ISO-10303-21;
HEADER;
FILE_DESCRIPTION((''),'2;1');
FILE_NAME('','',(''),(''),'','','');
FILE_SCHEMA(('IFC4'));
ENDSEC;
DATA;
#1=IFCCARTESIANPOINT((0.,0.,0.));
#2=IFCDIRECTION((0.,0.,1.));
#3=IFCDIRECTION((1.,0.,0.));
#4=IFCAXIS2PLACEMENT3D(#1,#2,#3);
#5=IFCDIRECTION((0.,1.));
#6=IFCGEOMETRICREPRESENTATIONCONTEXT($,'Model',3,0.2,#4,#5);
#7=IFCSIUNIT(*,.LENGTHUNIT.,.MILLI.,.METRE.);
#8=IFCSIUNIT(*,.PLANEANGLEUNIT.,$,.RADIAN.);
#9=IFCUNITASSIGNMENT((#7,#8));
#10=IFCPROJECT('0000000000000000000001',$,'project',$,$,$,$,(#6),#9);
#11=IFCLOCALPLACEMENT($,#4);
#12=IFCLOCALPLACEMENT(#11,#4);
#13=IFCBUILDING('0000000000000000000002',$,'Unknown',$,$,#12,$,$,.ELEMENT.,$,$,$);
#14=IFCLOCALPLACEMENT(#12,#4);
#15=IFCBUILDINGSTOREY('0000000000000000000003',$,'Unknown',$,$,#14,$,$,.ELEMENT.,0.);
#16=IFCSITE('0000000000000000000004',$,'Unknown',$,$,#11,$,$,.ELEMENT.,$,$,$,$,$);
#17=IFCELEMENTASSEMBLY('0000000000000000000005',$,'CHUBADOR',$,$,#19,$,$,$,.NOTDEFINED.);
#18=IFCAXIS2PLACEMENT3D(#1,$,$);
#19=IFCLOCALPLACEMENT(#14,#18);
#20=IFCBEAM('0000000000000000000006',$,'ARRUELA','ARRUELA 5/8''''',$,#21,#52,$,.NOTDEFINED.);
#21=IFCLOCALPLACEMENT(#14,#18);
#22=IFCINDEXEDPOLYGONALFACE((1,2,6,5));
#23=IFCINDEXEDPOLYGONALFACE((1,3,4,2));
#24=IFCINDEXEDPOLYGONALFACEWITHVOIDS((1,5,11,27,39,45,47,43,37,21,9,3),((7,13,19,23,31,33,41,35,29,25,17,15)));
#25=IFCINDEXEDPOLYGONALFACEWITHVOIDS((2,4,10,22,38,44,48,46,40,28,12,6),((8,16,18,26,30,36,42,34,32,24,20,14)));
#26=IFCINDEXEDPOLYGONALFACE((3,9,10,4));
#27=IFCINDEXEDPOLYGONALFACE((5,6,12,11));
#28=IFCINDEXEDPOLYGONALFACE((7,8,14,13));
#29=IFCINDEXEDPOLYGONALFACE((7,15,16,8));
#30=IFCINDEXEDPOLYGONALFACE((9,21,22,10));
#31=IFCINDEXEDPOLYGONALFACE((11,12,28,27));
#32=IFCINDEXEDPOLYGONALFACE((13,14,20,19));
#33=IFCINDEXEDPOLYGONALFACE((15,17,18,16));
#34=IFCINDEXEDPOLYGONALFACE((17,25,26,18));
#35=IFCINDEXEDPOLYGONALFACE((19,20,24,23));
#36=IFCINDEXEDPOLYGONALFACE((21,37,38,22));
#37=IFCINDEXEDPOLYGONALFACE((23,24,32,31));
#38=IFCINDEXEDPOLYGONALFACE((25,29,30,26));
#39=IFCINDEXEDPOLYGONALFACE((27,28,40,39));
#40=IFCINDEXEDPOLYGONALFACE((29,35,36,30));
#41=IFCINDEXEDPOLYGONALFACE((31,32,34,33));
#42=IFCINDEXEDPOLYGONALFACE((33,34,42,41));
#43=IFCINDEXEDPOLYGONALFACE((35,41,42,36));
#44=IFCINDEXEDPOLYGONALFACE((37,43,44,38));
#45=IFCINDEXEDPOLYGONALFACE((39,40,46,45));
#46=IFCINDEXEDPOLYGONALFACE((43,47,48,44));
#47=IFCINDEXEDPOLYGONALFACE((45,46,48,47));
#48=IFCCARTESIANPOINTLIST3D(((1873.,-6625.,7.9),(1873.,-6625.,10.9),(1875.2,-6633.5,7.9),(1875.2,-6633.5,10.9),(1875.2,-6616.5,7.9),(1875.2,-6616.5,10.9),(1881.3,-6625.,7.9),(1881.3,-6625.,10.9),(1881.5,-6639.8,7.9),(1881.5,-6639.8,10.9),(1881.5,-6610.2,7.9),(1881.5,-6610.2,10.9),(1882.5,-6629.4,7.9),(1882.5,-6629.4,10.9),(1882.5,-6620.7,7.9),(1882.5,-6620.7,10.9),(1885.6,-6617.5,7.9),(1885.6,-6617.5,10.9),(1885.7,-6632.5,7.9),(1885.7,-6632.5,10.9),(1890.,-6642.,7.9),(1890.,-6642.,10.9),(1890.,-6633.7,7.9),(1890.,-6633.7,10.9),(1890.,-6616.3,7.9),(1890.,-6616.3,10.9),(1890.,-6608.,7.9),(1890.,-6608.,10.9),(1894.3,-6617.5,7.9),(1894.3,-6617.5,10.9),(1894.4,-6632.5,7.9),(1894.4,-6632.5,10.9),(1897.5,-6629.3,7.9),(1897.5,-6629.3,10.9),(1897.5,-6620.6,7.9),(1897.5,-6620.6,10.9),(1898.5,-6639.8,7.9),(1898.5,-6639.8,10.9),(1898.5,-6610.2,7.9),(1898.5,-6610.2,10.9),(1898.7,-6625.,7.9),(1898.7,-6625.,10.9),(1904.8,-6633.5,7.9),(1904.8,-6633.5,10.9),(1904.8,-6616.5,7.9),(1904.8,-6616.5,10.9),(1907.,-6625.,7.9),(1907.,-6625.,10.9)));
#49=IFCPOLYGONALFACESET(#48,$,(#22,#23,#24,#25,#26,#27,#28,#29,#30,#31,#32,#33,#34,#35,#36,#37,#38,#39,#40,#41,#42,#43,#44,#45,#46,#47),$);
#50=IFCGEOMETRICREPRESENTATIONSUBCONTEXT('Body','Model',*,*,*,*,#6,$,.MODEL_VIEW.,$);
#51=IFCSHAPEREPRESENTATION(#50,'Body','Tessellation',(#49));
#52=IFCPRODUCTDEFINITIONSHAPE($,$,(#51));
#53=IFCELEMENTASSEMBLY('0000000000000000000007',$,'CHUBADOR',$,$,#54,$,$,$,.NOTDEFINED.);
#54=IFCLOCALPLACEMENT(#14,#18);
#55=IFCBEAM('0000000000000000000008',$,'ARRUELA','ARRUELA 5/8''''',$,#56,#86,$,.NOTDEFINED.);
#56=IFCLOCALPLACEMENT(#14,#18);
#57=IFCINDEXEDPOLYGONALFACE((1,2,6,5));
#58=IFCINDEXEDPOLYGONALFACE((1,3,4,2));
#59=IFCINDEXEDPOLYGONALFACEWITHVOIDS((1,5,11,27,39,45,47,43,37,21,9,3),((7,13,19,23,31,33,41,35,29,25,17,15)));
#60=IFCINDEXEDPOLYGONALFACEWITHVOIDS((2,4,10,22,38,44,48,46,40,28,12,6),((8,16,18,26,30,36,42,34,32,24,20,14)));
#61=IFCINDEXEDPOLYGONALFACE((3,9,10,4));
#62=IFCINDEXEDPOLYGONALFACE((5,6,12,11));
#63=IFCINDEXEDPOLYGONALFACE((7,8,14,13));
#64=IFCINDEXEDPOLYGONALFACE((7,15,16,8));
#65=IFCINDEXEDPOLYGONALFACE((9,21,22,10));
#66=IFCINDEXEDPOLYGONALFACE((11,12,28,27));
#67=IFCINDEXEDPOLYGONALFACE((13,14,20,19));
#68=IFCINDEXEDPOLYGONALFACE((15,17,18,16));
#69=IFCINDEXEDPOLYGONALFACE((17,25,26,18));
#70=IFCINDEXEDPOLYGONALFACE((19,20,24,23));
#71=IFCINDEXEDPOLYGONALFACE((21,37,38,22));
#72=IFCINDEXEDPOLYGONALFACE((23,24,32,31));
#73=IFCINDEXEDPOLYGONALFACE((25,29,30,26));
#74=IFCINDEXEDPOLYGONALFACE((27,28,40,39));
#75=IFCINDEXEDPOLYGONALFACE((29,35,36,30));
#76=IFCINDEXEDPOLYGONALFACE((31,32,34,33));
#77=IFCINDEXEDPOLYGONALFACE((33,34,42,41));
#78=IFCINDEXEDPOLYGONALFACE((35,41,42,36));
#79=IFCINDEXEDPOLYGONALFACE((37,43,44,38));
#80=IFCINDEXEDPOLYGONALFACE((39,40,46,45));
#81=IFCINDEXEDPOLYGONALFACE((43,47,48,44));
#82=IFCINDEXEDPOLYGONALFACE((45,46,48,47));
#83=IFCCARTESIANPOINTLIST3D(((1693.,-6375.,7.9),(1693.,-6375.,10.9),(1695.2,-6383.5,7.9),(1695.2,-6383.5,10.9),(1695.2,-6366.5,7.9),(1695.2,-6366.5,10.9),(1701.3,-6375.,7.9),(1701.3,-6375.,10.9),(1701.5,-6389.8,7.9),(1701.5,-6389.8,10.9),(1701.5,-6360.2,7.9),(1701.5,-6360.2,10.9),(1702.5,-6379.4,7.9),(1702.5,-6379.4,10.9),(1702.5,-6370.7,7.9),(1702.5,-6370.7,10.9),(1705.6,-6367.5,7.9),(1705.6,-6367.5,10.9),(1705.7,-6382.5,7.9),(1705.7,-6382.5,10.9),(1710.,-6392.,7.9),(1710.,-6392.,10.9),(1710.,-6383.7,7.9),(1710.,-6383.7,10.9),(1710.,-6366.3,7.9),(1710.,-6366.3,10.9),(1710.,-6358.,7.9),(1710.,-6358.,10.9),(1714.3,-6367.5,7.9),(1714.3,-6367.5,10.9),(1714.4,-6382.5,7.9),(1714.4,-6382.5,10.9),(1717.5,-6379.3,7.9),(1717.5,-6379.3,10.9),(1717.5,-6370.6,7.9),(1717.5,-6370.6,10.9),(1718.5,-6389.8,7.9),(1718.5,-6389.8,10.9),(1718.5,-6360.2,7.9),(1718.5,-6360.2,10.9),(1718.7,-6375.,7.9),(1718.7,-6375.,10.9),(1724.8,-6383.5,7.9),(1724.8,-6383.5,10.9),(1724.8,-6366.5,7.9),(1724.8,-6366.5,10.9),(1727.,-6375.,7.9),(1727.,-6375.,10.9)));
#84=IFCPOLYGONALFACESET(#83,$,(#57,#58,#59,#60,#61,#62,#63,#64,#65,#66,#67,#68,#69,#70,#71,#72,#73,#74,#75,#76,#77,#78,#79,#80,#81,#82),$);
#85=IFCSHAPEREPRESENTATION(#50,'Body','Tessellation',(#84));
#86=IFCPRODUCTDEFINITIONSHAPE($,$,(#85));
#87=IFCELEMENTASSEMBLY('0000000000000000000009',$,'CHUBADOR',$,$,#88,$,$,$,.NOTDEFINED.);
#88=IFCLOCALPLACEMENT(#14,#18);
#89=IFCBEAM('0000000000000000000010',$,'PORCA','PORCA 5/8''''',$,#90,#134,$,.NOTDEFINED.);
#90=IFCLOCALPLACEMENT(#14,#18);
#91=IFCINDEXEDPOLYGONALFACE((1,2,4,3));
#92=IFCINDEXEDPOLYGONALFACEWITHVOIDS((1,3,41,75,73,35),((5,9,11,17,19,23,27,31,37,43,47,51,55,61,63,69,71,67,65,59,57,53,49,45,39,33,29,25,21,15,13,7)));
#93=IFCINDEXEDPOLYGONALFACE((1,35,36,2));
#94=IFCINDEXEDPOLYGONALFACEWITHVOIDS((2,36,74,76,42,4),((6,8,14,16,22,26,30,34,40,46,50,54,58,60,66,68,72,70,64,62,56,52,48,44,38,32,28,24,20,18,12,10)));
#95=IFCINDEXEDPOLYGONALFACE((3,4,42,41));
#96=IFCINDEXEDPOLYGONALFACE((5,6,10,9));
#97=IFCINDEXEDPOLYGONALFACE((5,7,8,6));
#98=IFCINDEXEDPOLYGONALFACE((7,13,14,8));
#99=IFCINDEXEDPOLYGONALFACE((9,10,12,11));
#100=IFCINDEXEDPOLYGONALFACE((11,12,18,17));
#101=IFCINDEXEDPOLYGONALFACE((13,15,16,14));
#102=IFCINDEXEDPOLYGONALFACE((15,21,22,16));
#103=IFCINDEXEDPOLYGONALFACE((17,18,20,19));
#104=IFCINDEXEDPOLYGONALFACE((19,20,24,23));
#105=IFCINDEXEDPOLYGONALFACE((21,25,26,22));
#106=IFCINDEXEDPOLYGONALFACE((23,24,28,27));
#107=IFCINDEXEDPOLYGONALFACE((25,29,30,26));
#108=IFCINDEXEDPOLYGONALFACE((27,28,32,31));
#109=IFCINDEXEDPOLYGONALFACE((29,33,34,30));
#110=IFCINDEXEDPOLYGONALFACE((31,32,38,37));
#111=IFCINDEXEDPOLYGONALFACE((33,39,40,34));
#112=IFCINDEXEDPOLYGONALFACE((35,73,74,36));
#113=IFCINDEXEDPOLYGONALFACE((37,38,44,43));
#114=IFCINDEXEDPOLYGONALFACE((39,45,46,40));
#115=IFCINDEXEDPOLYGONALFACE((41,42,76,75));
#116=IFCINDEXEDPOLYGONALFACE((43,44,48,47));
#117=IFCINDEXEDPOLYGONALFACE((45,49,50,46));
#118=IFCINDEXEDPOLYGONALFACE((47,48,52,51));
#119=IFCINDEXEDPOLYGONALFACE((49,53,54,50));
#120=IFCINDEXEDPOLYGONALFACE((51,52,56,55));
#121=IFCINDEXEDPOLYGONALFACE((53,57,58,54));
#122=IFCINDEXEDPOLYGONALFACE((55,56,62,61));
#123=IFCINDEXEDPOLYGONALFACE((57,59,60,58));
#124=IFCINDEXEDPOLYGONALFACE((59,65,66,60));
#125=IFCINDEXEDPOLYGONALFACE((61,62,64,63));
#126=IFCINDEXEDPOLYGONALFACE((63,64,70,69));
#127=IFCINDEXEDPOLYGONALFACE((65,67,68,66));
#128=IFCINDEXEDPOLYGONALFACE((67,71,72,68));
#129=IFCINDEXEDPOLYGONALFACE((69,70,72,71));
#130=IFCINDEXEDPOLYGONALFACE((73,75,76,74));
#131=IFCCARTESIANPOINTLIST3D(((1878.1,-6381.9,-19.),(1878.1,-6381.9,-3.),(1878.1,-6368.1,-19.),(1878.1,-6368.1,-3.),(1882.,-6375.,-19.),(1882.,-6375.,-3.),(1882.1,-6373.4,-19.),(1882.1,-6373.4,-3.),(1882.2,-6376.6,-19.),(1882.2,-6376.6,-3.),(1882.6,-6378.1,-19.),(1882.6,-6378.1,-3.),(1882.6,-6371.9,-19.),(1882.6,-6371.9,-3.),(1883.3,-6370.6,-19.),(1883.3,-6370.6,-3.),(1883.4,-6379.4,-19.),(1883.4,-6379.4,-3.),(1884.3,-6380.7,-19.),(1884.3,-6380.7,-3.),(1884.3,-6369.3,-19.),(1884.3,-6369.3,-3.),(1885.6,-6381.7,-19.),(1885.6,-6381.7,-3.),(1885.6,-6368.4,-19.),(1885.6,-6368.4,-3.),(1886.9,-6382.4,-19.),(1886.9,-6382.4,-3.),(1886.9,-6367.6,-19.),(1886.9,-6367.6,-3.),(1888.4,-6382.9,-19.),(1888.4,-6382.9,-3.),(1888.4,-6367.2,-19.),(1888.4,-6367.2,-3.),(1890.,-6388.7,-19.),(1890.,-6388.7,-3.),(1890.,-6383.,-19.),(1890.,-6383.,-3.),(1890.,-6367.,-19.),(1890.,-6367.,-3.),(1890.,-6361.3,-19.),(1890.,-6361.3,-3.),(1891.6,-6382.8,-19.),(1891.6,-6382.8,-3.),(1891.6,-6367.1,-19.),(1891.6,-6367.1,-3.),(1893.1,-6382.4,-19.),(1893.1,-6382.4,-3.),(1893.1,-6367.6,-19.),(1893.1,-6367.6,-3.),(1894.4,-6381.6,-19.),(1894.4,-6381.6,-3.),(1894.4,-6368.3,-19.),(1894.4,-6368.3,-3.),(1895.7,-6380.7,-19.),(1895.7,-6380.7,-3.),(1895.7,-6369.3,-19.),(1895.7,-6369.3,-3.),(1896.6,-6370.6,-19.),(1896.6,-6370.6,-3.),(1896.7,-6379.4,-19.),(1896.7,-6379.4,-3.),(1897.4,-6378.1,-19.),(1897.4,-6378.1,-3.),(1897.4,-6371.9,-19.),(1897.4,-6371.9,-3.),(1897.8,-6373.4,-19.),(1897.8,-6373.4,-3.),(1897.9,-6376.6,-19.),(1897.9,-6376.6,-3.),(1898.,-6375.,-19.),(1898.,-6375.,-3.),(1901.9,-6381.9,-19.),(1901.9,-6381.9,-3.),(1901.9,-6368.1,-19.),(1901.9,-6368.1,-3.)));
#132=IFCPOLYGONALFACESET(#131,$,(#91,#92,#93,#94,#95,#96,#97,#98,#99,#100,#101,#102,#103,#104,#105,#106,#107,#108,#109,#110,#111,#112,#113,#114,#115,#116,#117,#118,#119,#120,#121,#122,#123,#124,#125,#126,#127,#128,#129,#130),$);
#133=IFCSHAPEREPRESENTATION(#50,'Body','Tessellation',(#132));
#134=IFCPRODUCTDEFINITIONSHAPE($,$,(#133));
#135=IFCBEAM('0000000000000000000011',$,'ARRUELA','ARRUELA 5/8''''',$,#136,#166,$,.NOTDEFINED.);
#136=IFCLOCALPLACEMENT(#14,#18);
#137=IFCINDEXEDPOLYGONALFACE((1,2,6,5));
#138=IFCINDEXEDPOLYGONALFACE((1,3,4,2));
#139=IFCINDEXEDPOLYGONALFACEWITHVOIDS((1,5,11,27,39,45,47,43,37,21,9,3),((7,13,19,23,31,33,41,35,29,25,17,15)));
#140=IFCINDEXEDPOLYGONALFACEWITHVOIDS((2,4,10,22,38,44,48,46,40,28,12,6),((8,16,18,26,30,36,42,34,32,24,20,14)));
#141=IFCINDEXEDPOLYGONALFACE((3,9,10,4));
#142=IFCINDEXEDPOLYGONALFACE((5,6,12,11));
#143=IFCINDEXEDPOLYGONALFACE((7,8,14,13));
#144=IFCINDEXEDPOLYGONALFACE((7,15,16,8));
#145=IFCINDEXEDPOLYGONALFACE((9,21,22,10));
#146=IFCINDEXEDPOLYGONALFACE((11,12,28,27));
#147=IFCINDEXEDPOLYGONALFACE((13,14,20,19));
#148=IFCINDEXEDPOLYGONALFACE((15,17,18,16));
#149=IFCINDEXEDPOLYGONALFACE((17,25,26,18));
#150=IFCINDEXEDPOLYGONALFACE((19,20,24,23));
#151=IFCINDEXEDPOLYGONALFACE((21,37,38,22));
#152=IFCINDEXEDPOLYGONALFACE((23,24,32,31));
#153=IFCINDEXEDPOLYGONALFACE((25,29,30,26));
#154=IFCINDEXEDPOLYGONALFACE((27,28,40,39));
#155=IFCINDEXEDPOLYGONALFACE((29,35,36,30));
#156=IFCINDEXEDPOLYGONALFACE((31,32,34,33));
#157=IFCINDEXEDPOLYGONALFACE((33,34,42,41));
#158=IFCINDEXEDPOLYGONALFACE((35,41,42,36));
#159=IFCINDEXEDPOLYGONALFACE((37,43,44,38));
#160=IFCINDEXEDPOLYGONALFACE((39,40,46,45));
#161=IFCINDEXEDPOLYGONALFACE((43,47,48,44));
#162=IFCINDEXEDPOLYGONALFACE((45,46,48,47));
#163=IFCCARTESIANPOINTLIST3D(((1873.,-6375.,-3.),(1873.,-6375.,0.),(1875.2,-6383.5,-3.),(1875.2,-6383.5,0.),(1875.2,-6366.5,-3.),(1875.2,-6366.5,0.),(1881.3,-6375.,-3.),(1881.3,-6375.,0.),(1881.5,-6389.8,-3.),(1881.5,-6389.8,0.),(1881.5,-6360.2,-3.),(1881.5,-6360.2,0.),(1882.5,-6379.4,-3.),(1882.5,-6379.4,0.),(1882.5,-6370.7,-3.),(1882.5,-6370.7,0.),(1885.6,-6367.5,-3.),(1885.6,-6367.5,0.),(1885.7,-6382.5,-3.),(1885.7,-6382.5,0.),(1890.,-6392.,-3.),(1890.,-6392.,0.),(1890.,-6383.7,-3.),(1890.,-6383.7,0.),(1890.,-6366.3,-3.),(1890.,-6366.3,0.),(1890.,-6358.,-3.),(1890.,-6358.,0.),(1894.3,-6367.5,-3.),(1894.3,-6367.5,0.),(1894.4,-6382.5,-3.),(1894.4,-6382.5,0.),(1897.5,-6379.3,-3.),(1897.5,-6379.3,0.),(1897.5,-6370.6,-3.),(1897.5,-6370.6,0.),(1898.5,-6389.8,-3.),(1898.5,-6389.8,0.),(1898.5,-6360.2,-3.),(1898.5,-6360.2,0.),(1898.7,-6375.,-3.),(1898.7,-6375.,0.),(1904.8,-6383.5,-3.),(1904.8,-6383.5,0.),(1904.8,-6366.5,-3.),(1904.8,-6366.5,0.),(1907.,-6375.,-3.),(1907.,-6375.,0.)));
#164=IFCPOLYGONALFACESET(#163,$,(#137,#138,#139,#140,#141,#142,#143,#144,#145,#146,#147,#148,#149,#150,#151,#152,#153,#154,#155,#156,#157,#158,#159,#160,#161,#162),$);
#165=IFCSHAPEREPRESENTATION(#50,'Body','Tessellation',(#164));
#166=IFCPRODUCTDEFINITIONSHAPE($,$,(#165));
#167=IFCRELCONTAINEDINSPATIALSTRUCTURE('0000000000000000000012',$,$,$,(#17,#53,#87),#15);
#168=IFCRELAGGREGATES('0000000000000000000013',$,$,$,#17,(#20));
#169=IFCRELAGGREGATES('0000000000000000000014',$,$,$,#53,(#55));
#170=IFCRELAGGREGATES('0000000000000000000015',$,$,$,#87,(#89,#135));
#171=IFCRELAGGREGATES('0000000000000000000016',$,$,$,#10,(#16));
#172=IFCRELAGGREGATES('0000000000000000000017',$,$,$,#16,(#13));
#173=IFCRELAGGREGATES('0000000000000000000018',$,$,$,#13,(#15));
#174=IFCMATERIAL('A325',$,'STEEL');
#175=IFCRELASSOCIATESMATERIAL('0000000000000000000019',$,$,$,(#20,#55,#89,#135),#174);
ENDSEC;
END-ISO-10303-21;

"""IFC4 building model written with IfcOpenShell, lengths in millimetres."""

from ifc_helpers import new_model, si_unit, direction, frame, origin_with_axes, place, context, subcontext, project, spatial, line, indexed_curve, outline, extrude, material, element, aggregate, save


model = new_model("IFC4")

# Units and contexts
model_context = context("Model", 3, precision=0.2, world=origin_with_axes(), true_north=direction((0.0, 1.0)))
body_context = subcontext(model_context, "Body", "Model", "MODEL_VIEW")
ifc_project = project(units=[si_unit("LENGTHUNIT", "METRE", prefix="MILLI"), si_unit("PLANEANGLEUNIT", "RADIAN")], contexts=[model_context])

# Site, building, storey
site_placement = place(None, origin_with_axes())
site = spatial("IfcSite", under=ifc_project, at=site_placement, Name="Unknown", CompositionType="ELEMENT")
building_placement = place(site_placement, origin_with_axes())
building = spatial("IfcBuilding", under=site, at=building_placement, Name="Unknown", CompositionType="ELEMENT")
storey_placement = place(building_placement, origin_with_axes())
storey = spatial("IfcBuildingStorey", under=building, at=storey_placement, Name="Unknown", CompositionType="ELEMENT", Elevation=0.0)

# Shared definitions
ifc_material_1 = material(Name="A325", Category="STEEL")

# Element assembly, beam
assembly_1_placement = place(storey_placement, frame((1890.0, -6625.0, -52.1), z_axis=(1.0, 0.0, 0.0), x_axis=(0.0, 0.0, -1.0)))
assembly_1 = element("IfcElementAssembly", 1, at=assembly_1_placement, inside=storey, Name="CHUBADOR", PredefinedType="NOTDEFINED")
beam_1_placement = place(assembly_1_placement, frame((-63.0, 0.0, 0.0), z_axis=(0.0, 0.0, 1.0), x_axis=(1.0, 0.0, 0.0)))
beam_1 = element("IfcBeam", 2, at=beam_1_placement, material=ifc_material_1, Name="ARRUELA", Description="ARRUELA 5/8''", PredefinedType="NOTDEFINED", context=body_context, shape_type="SolidModel", body=[
    extrude(outline(indexed_curve([(17.0, 0.0), (14.8, 8.5), (8.5, 14.8), (0.0, 17.0), (-8.5, 14.8), (-14.8, 8.5), (-17.0, 0.0), (-14.8, -8.5), (-8.5, -14.8), (0.0, -17.0), (8.5, -14.8), (14.8, -8.5)], segments=[line(1, 2, 3, 4, 5, 6, 7, 8, 9, 10, 11, 12, 1)]), holes=[indexed_curve([(8.7, 0.0), (7.5, -4.3), (4.3, -7.5), (0.0, -8.7), (-4.3, -7.5), (-7.5, -4.3), (-8.7, 0.0), (-7.5, 4.3), (-4.3, 7.5), (0.0, 8.7), (4.3, 7.5), (7.5, 4.3)], segments=[line(1, 2, 3, 4, 5, 6, 7, 8, 9, 10, 11, 12, 1)])]), frame((0.0, 0.0, 0.0), z_axis=(-1.0, 0.0, 0.0), x_axis=(0.0, 0.0, 1.0)), (0.0, 0.0, -1.0), 3.0),
])
aggregate(assembly_1, [beam_1])

# Element assembly, beam
assembly_2_placement = place(storey_placement, frame((1710.0, -6375.0, -52.1), z_axis=(-1.0, 0.0, 0.0), x_axis=(0.0, 0.0, -1.0)))
assembly_2 = element("IfcElementAssembly", 3, at=assembly_2_placement, inside=storey, Name="CHUBADOR", PredefinedType="NOTDEFINED")
beam_2_placement = place(assembly_2_placement, frame((-63.0, 0.0, 0.0), z_axis=(0.0, 0.0, 1.0), x_axis=(1.0, 0.0, 0.0)))
beam_2 = element("IfcBeam", 4, at=beam_2_placement, material=ifc_material_1, Name="ARRUELA", Description="ARRUELA 5/8''", PredefinedType="NOTDEFINED", context=body_context, shape_type="SolidModel", body=[
    extrude(outline(indexed_curve([(17.0, 0.0), (14.8, 8.5), (8.5, 14.8), (0.0, 17.0), (-8.5, 14.8), (-14.8, 8.5), (-17.0, 0.0), (-14.8, -8.5), (-8.5, -14.8), (0.0, -17.0), (8.5, -14.8), (14.8, -8.5)], segments=[line(1, 2, 3, 4, 5, 6, 7, 8, 9, 10, 11, 12, 1)]), holes=[indexed_curve([(8.7, 0.0), (7.5, -4.3), (4.3, -7.5), (0.0, -8.7), (-4.3, -7.5), (-7.5, -4.3), (-8.7, 0.0), (-7.5, 4.3), (-4.3, 7.5), (0.0, 8.7), (4.3, 7.5), (7.5, 4.3)], segments=[line(1, 2, 3, 4, 5, 6, 7, 8, 9, 10, 11, 12, 1)])]), frame((0.0, 0.0, 0.0), z_axis=(-1.0, 0.0, 0.0), x_axis=(0.0, 0.0, 1.0)), (0.0, 0.0, -1.0), 3.0),
])
aggregate(assembly_2, [beam_2])

# Element assembly, beams
assembly_3_placement = place(storey_placement, frame((1890.0, -6375.0, -52.1), z_axis=(1.0, 0.0, 0.0), x_axis=(0.0, 0.0, -1.0)))
assembly_3 = element("IfcElementAssembly", 5, at=assembly_3_placement, inside=storey, Name="CHUBADOR", PredefinedType="NOTDEFINED")
beam_3_placement = place(assembly_3_placement, frame((-49.1, 0.0, 0.0), z_axis=(0.0, 0.0, 1.0), x_axis=(1.0, 0.0, 0.0)))
beam_3 = element("IfcBeam", 6, at=beam_3_placement, material=ifc_material_1, Name="PORCA", Description="PORCA 5/8''", PredefinedType="NOTDEFINED", context=body_context, shape_type="SolidModel", body=[
    extrude(outline(indexed_curve([(0.0, 13.8), (-11.9, 6.9), (-11.9, -6.9), (0.0, -13.8), (11.9, -6.9), (11.9, 6.9)], segments=[line(1, 2, 3, 4, 5, 6, 1)]), holes=[indexed_curve([(7.8, 1.6), (8.0, 0.0), (7.8, -1.6), (7.4, -3.1), (6.7, -4.4), (5.7, -5.7), (4.4, -6.7), (3.1, -7.4), (1.6, -7.8), (0.0, -8.0), (-1.6, -7.8), (-3.1, -7.4), (-4.4, -6.7), (-5.7, -5.7), (-6.7, -4.4), (-7.4, -3.1), (-7.8, -1.6), (-8.0, 0.0), (-7.8, 1.6), (-7.4, 3.1), (-6.7, 4.4), (-5.7, 5.7), (-4.4, 6.7), (-3.1, 7.4), (-1.6, 7.8), (0.0, 8.0), (1.6, 7.8), (3.1, 7.4), (4.4, 6.7), (5.7, 5.7), (6.7, 4.4), (7.4, 3.1)], segments=[line(1, 2, 3, 4, 5, 6, 7, 8, 9, 10, 11, 12, 13, 14, 15, 16, 17, 18, 19, 20, 21, 22, 23, 24, 25, 26, 27, 28, 29, 30, 31, 32, 1)])]), frame((0.0, 0.0, 0.0), z_axis=(-1.0, 0.0, 0.0), x_axis=(0.0, 0.0, 1.0)), (0.0, 0.0, -1.0), 16.0),
])
beam_4_placement = place(assembly_3_placement, frame((-52.1, 0.0, 0.0), z_axis=(0.0, 0.0, 1.0), x_axis=(1.0, 0.0, 0.0)))
beam_4 = element("IfcBeam", 7, at=beam_4_placement, material=ifc_material_1, Name="ARRUELA", Description="ARRUELA 5/8''", PredefinedType="NOTDEFINED", context=body_context, shape_type="SolidModel", body=[
    extrude(outline(indexed_curve([(17.0, 0.0), (14.8, 8.5), (8.5, 14.8), (0.0, 17.0), (-8.5, 14.8), (-14.8, 8.5), (-17.0, 0.0), (-14.8, -8.5), (-8.5, -14.8), (0.0, -17.0), (8.5, -14.8), (14.8, -8.5)], segments=[line(1, 2, 3, 4, 5, 6, 7, 8, 9, 10, 11, 12, 1)]), holes=[indexed_curve([(8.7, 0.0), (7.5, -4.3), (4.3, -7.5), (0.0, -8.7), (-4.3, -7.5), (-7.5, -4.3), (-8.7, 0.0), (-7.5, 4.3), (-4.3, 7.5), (0.0, 8.7), (4.3, 7.5), (7.5, 4.3)], segments=[line(1, 2, 3, 4, 5, 6, 7, 8, 9, 10, 11, 12, 1)])]), frame((0.0, 0.0, 0.0), z_axis=(-1.0, 0.0, 0.0), x_axis=(0.0, 0.0, 1.0)), (0.0, 0.0, -1.0), 3.0),
])
aggregate(assembly_3, [beam_3, beam_4])

save(model, "model.ifc")
